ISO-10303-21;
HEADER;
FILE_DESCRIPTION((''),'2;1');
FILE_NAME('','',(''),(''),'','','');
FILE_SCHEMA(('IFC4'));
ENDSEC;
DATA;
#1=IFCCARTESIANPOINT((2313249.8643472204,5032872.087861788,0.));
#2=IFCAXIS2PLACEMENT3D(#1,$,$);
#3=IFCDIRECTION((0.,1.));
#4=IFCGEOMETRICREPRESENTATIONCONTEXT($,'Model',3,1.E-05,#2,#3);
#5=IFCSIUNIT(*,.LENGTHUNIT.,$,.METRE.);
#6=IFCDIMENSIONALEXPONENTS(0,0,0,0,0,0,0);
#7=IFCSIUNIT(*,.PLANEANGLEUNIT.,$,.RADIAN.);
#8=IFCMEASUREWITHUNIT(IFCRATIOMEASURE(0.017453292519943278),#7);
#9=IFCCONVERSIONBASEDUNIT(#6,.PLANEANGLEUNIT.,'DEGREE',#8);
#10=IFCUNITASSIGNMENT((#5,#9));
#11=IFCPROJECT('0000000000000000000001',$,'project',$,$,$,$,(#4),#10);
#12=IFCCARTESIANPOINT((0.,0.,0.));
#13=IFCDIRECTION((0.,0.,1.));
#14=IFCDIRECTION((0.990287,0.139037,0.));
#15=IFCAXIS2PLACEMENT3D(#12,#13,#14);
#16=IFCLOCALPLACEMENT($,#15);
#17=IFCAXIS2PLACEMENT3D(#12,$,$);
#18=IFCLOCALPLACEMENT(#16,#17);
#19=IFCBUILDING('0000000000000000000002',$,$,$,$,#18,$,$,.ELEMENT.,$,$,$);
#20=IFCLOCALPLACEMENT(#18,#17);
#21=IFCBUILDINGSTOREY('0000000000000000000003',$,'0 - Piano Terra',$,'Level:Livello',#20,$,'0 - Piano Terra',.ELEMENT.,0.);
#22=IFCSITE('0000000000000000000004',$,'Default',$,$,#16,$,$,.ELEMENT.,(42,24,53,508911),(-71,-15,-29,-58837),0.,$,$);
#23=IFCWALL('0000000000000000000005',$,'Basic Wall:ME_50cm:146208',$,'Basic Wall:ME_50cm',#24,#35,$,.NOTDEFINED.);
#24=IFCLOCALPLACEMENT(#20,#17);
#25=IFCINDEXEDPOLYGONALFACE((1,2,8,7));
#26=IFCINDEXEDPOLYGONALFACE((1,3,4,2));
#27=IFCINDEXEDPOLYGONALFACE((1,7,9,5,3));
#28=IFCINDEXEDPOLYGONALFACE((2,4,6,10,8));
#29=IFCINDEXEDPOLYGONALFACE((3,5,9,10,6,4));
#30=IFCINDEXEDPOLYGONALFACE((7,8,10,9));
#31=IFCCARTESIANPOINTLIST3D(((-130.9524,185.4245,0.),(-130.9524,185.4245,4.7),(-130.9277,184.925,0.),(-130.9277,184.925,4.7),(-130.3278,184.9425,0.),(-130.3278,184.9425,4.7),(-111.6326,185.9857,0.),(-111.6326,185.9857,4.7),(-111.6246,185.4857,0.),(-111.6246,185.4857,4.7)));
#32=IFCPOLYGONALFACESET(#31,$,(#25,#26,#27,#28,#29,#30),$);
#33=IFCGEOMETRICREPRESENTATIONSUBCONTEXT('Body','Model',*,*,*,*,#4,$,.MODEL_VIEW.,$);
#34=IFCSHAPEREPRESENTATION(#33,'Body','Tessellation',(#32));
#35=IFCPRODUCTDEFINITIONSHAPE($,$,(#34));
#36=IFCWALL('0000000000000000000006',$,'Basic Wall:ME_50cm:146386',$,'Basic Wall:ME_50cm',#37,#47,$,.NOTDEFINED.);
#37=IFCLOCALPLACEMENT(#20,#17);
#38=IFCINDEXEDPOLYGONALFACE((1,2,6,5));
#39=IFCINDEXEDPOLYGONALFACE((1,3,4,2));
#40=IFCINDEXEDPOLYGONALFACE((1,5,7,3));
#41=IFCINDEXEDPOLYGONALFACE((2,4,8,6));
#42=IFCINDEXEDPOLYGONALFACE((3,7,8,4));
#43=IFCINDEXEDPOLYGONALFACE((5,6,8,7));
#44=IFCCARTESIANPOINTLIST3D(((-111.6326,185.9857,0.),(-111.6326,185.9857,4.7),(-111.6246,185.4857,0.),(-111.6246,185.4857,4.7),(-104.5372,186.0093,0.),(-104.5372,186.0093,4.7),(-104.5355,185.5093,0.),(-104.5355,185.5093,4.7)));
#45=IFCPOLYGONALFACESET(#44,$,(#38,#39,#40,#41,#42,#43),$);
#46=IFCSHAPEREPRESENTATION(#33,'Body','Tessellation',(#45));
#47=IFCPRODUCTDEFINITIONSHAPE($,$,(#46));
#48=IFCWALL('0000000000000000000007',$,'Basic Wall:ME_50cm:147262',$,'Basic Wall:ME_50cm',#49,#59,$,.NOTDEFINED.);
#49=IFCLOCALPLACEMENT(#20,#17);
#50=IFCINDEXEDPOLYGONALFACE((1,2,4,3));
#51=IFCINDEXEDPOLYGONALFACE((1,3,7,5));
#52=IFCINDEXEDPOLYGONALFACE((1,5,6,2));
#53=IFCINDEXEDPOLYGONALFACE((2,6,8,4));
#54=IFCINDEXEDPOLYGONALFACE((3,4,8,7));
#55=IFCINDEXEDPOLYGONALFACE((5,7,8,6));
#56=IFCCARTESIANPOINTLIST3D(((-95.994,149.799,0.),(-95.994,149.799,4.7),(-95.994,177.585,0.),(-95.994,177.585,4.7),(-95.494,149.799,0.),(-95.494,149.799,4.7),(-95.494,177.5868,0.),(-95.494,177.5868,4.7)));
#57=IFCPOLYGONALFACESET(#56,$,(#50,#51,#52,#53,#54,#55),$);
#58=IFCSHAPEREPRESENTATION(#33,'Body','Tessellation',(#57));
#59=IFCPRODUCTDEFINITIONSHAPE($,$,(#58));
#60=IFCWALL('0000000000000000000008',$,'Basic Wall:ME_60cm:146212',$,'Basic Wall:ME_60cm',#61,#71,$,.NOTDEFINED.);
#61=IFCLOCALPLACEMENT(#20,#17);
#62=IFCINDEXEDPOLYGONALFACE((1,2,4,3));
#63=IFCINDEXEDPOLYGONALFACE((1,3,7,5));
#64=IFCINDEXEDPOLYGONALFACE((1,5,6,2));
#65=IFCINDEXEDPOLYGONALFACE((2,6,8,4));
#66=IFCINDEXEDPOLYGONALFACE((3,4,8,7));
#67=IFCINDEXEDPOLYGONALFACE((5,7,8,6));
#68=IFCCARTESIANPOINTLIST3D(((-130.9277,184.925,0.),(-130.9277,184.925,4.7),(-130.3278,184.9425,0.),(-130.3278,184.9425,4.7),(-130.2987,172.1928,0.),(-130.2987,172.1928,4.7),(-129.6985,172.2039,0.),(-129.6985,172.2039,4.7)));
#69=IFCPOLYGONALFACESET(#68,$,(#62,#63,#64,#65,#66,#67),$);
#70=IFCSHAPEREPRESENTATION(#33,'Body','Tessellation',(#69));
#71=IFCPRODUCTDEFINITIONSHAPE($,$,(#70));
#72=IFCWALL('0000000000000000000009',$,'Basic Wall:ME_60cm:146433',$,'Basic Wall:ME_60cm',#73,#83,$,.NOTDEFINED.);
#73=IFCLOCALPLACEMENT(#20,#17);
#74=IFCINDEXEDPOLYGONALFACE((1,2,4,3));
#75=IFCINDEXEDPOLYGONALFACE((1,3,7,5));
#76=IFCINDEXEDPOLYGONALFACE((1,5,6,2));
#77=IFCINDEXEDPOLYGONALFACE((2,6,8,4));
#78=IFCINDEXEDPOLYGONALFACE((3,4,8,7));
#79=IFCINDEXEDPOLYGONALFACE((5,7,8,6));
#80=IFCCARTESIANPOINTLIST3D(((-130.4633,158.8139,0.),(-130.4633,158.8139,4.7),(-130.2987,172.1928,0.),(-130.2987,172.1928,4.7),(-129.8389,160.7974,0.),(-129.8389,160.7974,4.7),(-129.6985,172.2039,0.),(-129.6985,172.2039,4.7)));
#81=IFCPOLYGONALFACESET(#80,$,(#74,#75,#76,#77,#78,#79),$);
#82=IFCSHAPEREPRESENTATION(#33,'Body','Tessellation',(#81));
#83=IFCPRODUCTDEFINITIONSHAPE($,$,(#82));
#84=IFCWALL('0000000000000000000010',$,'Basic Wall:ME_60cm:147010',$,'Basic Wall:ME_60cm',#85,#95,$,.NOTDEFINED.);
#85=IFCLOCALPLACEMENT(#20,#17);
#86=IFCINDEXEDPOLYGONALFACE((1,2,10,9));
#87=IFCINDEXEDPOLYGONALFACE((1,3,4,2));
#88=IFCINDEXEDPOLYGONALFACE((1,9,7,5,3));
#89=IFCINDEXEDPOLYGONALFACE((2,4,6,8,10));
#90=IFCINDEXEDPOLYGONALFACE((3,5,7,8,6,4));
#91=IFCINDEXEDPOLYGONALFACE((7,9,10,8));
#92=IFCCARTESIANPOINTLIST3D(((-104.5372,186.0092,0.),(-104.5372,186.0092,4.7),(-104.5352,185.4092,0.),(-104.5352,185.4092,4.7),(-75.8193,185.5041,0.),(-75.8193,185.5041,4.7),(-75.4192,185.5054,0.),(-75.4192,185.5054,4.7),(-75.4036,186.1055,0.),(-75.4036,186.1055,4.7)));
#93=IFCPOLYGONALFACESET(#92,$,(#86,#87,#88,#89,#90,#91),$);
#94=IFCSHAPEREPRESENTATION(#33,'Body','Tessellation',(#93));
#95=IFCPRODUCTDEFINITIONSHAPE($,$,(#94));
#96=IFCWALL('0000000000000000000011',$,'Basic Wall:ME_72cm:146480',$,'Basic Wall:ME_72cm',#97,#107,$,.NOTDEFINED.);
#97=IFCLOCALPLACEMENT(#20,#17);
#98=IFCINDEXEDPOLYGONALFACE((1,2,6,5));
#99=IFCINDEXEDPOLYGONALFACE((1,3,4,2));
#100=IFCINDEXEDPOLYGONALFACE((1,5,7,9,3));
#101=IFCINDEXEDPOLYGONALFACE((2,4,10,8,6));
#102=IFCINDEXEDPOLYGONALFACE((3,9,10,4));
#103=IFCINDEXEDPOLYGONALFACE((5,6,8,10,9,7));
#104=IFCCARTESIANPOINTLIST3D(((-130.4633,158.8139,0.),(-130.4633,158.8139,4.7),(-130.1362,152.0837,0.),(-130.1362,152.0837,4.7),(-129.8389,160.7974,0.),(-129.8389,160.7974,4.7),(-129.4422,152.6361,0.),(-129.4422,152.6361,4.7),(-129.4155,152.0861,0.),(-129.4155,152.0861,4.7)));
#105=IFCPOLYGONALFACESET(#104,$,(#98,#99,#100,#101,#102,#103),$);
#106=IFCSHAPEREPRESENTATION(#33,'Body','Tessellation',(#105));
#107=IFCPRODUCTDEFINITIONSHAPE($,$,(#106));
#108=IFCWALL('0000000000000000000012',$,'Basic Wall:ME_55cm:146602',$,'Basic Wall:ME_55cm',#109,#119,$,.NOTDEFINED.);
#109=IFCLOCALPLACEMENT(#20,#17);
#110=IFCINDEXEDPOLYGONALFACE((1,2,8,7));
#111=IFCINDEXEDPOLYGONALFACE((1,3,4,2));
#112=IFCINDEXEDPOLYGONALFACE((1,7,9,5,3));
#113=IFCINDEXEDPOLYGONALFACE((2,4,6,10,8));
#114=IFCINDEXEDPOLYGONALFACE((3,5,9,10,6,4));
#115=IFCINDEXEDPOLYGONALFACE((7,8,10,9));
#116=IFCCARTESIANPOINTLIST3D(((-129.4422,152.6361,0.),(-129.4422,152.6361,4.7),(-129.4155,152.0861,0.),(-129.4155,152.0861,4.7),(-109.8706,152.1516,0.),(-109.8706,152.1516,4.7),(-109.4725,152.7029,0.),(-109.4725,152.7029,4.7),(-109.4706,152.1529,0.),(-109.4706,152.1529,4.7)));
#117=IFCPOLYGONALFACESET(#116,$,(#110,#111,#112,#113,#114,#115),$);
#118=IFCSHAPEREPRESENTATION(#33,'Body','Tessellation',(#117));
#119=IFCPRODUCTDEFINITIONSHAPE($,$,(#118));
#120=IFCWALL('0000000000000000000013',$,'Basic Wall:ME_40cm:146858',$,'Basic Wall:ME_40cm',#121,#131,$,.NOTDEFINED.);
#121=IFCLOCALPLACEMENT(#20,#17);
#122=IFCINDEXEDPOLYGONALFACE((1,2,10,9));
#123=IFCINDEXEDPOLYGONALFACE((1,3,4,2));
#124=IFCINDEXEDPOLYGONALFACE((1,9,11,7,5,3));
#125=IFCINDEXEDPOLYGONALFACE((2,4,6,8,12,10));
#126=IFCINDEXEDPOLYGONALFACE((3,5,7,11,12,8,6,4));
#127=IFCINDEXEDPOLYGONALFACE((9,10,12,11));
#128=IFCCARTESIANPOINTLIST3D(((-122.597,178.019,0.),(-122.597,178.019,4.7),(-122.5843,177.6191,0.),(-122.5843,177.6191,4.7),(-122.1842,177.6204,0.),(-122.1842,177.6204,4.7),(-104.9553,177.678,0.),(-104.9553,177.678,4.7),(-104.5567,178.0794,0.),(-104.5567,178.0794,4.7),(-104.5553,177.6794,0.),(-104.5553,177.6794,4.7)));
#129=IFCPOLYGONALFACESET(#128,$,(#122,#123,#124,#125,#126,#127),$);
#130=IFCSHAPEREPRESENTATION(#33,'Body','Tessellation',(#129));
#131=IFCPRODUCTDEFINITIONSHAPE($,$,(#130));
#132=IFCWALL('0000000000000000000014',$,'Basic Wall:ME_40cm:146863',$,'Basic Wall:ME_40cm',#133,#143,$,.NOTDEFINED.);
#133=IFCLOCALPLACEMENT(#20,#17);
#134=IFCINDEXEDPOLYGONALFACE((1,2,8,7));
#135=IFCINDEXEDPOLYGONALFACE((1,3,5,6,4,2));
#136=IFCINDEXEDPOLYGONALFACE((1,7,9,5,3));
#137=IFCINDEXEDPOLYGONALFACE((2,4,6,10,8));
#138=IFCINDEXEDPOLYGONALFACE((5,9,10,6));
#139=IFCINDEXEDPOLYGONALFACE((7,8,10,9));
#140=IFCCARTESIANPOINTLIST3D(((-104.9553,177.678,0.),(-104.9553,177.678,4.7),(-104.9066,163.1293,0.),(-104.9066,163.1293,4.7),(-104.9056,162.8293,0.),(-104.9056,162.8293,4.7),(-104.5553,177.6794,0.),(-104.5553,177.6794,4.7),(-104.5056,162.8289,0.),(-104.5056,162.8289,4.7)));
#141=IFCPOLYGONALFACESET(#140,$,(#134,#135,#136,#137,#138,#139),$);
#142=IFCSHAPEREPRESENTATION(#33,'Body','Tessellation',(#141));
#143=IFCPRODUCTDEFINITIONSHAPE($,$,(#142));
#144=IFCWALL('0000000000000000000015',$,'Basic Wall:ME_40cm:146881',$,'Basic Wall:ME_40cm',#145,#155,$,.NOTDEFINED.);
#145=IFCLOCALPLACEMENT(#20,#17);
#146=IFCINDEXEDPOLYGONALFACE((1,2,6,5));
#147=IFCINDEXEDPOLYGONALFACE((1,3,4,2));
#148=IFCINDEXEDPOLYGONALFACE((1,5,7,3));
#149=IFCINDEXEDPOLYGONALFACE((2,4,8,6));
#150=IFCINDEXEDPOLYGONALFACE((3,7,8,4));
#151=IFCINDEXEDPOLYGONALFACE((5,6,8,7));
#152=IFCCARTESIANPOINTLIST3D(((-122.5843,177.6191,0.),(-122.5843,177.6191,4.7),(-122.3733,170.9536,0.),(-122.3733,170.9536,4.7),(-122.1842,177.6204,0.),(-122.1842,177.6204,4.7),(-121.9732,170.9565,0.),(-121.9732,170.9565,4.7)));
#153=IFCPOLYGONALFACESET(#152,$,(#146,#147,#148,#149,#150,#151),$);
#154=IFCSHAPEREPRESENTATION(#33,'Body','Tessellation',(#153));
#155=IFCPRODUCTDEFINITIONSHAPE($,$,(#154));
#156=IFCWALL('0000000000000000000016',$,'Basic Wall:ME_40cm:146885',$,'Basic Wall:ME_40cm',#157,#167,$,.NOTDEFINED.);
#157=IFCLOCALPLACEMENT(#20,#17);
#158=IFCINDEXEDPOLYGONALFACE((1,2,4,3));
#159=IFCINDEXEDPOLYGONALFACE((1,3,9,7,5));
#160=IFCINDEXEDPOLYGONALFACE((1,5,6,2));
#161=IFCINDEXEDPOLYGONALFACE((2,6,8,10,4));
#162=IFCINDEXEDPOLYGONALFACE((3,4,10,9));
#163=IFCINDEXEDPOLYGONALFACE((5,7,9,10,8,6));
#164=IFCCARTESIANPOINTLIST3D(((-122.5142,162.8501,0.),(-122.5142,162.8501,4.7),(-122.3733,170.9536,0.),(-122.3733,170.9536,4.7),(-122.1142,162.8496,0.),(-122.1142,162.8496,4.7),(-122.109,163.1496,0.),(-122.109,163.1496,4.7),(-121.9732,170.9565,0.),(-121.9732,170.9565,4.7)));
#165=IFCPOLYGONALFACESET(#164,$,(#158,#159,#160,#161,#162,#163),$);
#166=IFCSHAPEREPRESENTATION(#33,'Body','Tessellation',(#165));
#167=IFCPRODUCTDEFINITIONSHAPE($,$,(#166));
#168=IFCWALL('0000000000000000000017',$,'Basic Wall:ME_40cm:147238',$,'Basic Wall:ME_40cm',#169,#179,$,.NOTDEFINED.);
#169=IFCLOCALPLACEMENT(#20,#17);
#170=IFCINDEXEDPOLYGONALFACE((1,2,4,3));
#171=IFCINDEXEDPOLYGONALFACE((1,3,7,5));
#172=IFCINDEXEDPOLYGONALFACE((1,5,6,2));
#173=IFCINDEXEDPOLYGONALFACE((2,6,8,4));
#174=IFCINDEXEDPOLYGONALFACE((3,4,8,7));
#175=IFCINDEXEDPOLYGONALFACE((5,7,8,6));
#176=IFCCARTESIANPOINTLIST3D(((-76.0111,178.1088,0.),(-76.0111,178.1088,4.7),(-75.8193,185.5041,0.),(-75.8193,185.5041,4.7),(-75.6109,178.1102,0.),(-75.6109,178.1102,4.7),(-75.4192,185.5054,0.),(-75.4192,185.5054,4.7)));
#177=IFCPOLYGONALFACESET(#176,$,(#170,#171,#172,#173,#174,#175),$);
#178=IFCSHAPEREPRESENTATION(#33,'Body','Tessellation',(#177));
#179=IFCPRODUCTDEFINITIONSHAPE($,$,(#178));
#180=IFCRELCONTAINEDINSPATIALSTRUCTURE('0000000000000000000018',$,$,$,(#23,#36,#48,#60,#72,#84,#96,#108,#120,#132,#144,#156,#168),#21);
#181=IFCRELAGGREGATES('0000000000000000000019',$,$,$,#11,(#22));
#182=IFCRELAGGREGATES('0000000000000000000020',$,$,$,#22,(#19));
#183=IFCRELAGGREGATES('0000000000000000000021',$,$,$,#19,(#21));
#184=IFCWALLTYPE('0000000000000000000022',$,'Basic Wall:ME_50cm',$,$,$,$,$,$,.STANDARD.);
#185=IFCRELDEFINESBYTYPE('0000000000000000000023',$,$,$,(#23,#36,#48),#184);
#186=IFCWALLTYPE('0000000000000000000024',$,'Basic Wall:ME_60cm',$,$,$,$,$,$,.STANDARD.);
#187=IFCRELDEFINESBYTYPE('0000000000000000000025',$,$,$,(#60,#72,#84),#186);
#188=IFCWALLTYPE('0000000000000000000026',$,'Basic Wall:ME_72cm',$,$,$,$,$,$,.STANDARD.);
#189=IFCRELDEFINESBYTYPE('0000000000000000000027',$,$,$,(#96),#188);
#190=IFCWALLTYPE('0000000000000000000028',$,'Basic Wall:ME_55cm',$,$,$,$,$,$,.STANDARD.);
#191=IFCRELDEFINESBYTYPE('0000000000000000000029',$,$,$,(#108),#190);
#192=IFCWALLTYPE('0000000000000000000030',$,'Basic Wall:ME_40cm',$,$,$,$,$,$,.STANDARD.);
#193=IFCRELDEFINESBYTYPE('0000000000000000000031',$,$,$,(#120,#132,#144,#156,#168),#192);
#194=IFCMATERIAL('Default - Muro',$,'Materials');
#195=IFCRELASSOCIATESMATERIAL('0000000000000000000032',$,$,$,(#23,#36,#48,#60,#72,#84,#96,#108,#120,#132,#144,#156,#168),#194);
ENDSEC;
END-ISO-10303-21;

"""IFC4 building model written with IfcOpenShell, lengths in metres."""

from ifc_helpers import new_model, entity, si_unit, converted_unit, direction, frame, origin, place, context, subcontext, project, spatial, indexed_curve, outline, extrude, material, type_object, element, save


model = new_model("IFC4")

# Units and contexts
model_context = context("Model", 3, precision=1e-05, world=frame((2313249.8643472204, 5032872.087861788, 0.0)), true_north=direction((0.0, 1.0)))
body_context = subcontext(model_context, "Body", "Model", "MODEL_VIEW")
ifc_project = project(units=[si_unit("LENGTHUNIT", "METRE"), converted_unit("PLANEANGLEUNIT", "DEGREE", entity("IfcRatioMeasure", 0.017453292519943278), si_unit("PLANEANGLEUNIT", "RADIAN"), dimensions=[0, 0, 0, 0, 0, 0, 0])], contexts=[model_context])

# Site, building, storey
site_placement = place(None, frame((0.0, 0.0, 0.0), z_axis=(0.0, 0.0, 1.0), x_axis=(0.990287, 0.139037, 0.0)))
site = spatial("IfcSite", under=ifc_project, at=site_placement, Name="Default", CompositionType="ELEMENT", RefLatitude=(42, 24, 53, 508911), RefLongitude=(-71, -15, -29, -58837), RefElevation=0.0)
building_placement = place(site_placement, origin())
building = spatial("IfcBuilding", under=site, at=building_placement, CompositionType="ELEMENT")
storey_placement = place(building_placement, origin())
storey = spatial("IfcBuildingStorey", under=building, at=storey_placement, Name="0 - Piano Terra", ObjectType="Level:Livello", LongName="0 - Piano Terra", CompositionType="ELEMENT", Elevation=0.0)

# Walls
ifc_material = material(Name="Default - Muro", Category="Materials")
wall_type_1 = type_object("IfcWallType", Name="Basic Wall:ME_50cm", PredefinedType="STANDARD")
wall_1_placement = place(storey_placement, frame((-130.9451, 185.1746, 0.0), z_axis=(0.0, 0.0, 1.0), x_axis=(0.999578, 0.029032, 0.0)))
element("IfcWall", 1, at=wall_1_placement, inside=storey, type_object=wall_type_1, material=ifc_material, Name="Basic Wall:ME_50cm:146208", ObjectType="Basic Wall:ME_50cm", PredefinedType="NOTDEFINED", context=body_context, shape_type="SweptSolid", body=[
    extrude(outline(indexed_curve([(19.3214, -0.25), (19.3279, 0.25), (0.0, 0.25), (0.0102, -0.25), (0.6103, -0.25), (19.3214, -0.25)], self_intersect=False)), origin(), (0.0, 0.0, 1.0), 4.7),
])
wall_2_placement = place(storey_placement, frame((-111.6318, 185.7357, 0.0), z_axis=(0.0, 0.0, 1.0), x_axis=(0.999994, 0.003327, 0.0)))
element("IfcWall", 2, at=wall_2_placement, inside=storey, type_object=wall_type_1, material=ifc_material, Name="Basic Wall:ME_50cm:146386", ObjectType="Basic Wall:ME_50cm", PredefinedType="NOTDEFINED", context=body_context, shape_type="SweptSolid", body=[
    extrude(outline(indexed_curve([(7.0955, -0.25), (7.0955, 0.25), (0.0, 0.25), (0.0064, -0.25), (7.0955, -0.25)], self_intersect=False)), origin(), (0.0, 0.0, 1.0), 4.7),
])
wall_3_placement = place(storey_placement, frame((-95.744, 177.5868, 0.0), z_axis=(0.0, 0.0, 1.0), x_axis=(0.0, -1.0, 0.0)))
element("IfcWall", 3, at=wall_3_placement, inside=storey, type_object=wall_type_1, material=ifc_material, Name="Basic Wall:ME_50cm:147262", ObjectType="Basic Wall:ME_50cm", PredefinedType="NOTDEFINED", context=body_context, shape_type="SweptSolid", body=[
    extrude(outline(indexed_curve([(27.7878, -0.25), (27.7878, 0.25), (0.0, 0.25), (0.0018, -0.25), (27.7878, -0.25)], self_intersect=False)), origin(), (0.0, 0.0, 1.0), 4.7),
])
wall_type_2 = type_object("IfcWallType", Name="Basic Wall:ME_60cm", PredefinedType="STANDARD")
wall_4_placement = place(storey_placement, frame((-129.9982, 172.1891, 0.0), z_axis=(0.0, 0.0, 1.0), x_axis=(-0.049339, 0.998782, 0.0)))
element("IfcWall", 4, at=wall_4_placement, inside=storey, type_object=wall_type_2, material=ifc_material, Name="Basic Wall:ME_60cm:146212", ObjectType="Basic Wall:ME_60cm", PredefinedType="NOTDEFINED", context=body_context, shape_type="SweptSolid", body=[
    extrude(outline(indexed_curve([(12.7541, -0.3), (12.7663, 0.3), (0.0185, 0.3), (0.0, -0.3), (12.7541, -0.3)], self_intersect=False)), origin(), (0.0, 0.0, 1.0), 4.7),
])
wall_5_placement = place(storey_placement, frame((-130.1634, 158.8102, 0.0), z_axis=(0.0, 0.0, 1.0), x_axis=(0.012302, 0.999924, 0.0)))
element("IfcWall", 5, at=wall_5_placement, inside=storey, type_object=wall_type_2, material=ifc_material, Name="Basic Wall:ME_60cm:146433", ObjectType="Basic Wall:ME_60cm", PredefinedType="NOTDEFINED", context=body_context, shape_type="SweptSolid", body=[
    extrude(outline(indexed_curve([(13.3984, -0.3), (13.3799, 0.3), (0.0, 0.3), (1.9911, -0.3), (13.3984, -0.3)], self_intersect=False)), origin(), (0.0, 0.0, 1.0), 4.7),
])
wall_6_placement = place(storey_placement, frame((-104.5362, 185.7092, 0.0), z_axis=(0.0, 0.0, 1.0), x_axis=(0.999995, 0.003303, 0.0)))
element("IfcWall", 6, at=wall_6_placement, inside=storey, type_object=wall_type_2, material=ifc_material, Name="Basic Wall:ME_60cm:147010", ObjectType="Basic Wall:ME_60cm", PredefinedType="NOTDEFINED", context=body_context, shape_type="SweptSolid", body=[
    extrude(outline(indexed_curve([(29.1162, -0.3), (29.1337, 0.3), (0.0, 0.3), (0.0, -0.3), (28.716, -0.3), (29.1162, -0.3)], self_intersect=False)), origin(), (0.0, 0.0, 1.0), 4.7),
])
wall_type_3 = type_object("IfcWallType", Name="Basic Wall:ME_72cm", PredefinedType="STANDARD")
wall_7_placement = place(storey_placement, frame((-129.7751, 152.0687, 0.0), z_axis=(0.0, 0.0, 1.0), x_axis=(-0.048543, 0.998821, 0.0)))
element("IfcWall", 7, at=wall_7_placement, inside=storey, type_object=wall_type_3, material=ifc_material, Name="Basic Wall:ME_72cm:146480", ObjectType="Basic Wall:ME_72cm", PredefinedType="NOTDEFINED", context=body_context, shape_type="SweptSolid", body=[
    extrude(outline(indexed_curve([(8.7216, -0.36), (6.7707, 0.36), (0.0326, 0.36), (0.0, -0.36), (0.5506, -0.36), (8.7216, -0.36)], self_intersect=False)), origin(), (0.0, 0.0, 1.0), 4.7),
])
wall_type_4 = type_object("IfcWallType", Name="Basic Wall:ME_55cm", PredefinedType="STANDARD")
wall_8_placement = place(storey_placement, frame((-109.4715, 152.4279, 0.0), z_axis=(0.0, 0.0, 1.0), x_axis=(-0.999994, -0.003349, 0.0)))
element("IfcWall", 8, at=wall_8_placement, inside=storey, type_object=wall_type_4, material=ifc_material, Name="Basic Wall:ME_55cm:146602", ObjectType="Basic Wall:ME_55cm", PredefinedType="NOTDEFINED", context=body_context, shape_type="SweptSolid", body=[
    extrude(outline(indexed_curve([(19.9699, -0.275), (19.945, 0.275), (0.4, 0.275), (0.0, 0.275), (0.0, -0.275), (19.9699, -0.275)], self_intersect=False)), origin(), (0.0, 0.0, 1.0), 4.7),
])
wall_type_5 = type_object("IfcWallType", Name="Basic Wall:ME_40cm", PredefinedType="STANDARD")
wall_9_placement = place(storey_placement, frame((-104.556, 177.8794, 0.0), z_axis=(0.0, 0.0, 1.0), x_axis=(-0.999994, -0.003344, 0.0)))
element("IfcWall", 9, at=wall_9_placement, inside=storey, type_object=wall_type_5, material=ifc_material, Name="Basic Wall:ME_40cm:146858", ObjectType="Basic Wall:ME_40cm", PredefinedType="NOTDEFINED", context=body_context, shape_type="SweptSolid", body=[
    extrude(outline(indexed_curve([(18.0404, -0.2), (18.0291, 0.2), (17.6289, 0.2), (0.4, 0.2), (0.0, 0.2), (0.0, -0.2), (18.0404, -0.2)], self_intersect=False)), origin(), (0.0, 0.0, 1.0), 4.7),
])
wall_10_placement = place(storey_placement, frame((-104.7553, 177.6787, 0.0), z_axis=(0.0, 0.0, 1.0), x_axis=(0.00335, -0.999994, 0.0)))
element("IfcWall", 10, at=wall_10_placement, inside=storey, type_object=wall_type_5, material=ifc_material, Name="Basic Wall:ME_40cm:146863", ObjectType="Basic Wall:ME_40cm", PredefinedType="NOTDEFINED", context=body_context, shape_type="SweptSolid", body=[
    extrude(outline(indexed_curve([(14.8488, -0.2), (14.8506, 0.2), (0.0, 0.2), (0.0, -0.2), (14.5488, -0.2), (14.8488, -0.2)], self_intersect=False)), origin(), (0.0, 0.0, 1.0), 4.7),
])
wall_11_placement = place(storey_placement, frame((-122.3844, 177.6254, 0.0), z_axis=(0.0, 0.0, 1.0), x_axis=(0.031639, -0.999499, 0.0)))
element("IfcWall", 11, at=wall_11_placement, inside=storey, type_object=wall_type_5, material=ifc_material, Name="Basic Wall:ME_40cm:146881", ObjectType="Basic Wall:ME_40cm", PredefinedType="NOTDEFINED", context=body_context, shape_type="SweptSolid", body=[
    extrude(outline(indexed_curve([(6.6688, -0.2), (6.6786, 0.2), (0.0113, 0.2), (0.0, -0.2), (6.6688, -0.2)], self_intersect=False)), origin(), (0.0, 0.0, 1.0), 4.7),
])
wall_12_placement = place(storey_placement, frame((-122.1732, 170.96, 0.0), z_axis=(0.0, 0.0, 1.0), x_axis=(-0.017388, -0.999849, 0.0)))
element("IfcWall", 12, at=wall_12_placement, inside=storey, type_object=wall_type_5, material=ifc_material, Name="Basic Wall:ME_40cm:146885", ObjectType="Basic Wall:ME_40cm", PredefinedType="NOTDEFINED", context=body_context, shape_type="SweptSolid", body=[
    extrude(outline(indexed_curve([(8.1146, -0.2), (8.1081, 0.2), (7.8081, 0.2), (0.0, 0.2), (0.0098, -0.2), (8.1146, -0.2)], self_intersect=False)), origin(), (0.0, 0.0, 1.0), 4.7),
])
wall_13_placement = place(storey_placement, frame((-75.8111, 178.1036, 0.0), z_axis=(0.0, 0.0, 1.0), x_axis=(0.025919, 0.999664, 0.0)))
element("IfcWall", 13, at=wall_13_placement, inside=storey, type_object=wall_type_5, material=ifc_material, Name="Basic Wall:ME_40cm:147238", ObjectType="Basic Wall:ME_40cm", PredefinedType="NOTDEFINED", context=body_context, shape_type="SweptSolid", body=[
    extrude(outline(indexed_curve([(7.4095, -0.2), (7.3978, 0.2), (0.0, 0.2), (0.0118, -0.2), (7.4095, -0.2)], self_intersect=False)), origin(), (0.0, 0.0, 1.0), 4.7),
])

save(model, "model.ifc")
